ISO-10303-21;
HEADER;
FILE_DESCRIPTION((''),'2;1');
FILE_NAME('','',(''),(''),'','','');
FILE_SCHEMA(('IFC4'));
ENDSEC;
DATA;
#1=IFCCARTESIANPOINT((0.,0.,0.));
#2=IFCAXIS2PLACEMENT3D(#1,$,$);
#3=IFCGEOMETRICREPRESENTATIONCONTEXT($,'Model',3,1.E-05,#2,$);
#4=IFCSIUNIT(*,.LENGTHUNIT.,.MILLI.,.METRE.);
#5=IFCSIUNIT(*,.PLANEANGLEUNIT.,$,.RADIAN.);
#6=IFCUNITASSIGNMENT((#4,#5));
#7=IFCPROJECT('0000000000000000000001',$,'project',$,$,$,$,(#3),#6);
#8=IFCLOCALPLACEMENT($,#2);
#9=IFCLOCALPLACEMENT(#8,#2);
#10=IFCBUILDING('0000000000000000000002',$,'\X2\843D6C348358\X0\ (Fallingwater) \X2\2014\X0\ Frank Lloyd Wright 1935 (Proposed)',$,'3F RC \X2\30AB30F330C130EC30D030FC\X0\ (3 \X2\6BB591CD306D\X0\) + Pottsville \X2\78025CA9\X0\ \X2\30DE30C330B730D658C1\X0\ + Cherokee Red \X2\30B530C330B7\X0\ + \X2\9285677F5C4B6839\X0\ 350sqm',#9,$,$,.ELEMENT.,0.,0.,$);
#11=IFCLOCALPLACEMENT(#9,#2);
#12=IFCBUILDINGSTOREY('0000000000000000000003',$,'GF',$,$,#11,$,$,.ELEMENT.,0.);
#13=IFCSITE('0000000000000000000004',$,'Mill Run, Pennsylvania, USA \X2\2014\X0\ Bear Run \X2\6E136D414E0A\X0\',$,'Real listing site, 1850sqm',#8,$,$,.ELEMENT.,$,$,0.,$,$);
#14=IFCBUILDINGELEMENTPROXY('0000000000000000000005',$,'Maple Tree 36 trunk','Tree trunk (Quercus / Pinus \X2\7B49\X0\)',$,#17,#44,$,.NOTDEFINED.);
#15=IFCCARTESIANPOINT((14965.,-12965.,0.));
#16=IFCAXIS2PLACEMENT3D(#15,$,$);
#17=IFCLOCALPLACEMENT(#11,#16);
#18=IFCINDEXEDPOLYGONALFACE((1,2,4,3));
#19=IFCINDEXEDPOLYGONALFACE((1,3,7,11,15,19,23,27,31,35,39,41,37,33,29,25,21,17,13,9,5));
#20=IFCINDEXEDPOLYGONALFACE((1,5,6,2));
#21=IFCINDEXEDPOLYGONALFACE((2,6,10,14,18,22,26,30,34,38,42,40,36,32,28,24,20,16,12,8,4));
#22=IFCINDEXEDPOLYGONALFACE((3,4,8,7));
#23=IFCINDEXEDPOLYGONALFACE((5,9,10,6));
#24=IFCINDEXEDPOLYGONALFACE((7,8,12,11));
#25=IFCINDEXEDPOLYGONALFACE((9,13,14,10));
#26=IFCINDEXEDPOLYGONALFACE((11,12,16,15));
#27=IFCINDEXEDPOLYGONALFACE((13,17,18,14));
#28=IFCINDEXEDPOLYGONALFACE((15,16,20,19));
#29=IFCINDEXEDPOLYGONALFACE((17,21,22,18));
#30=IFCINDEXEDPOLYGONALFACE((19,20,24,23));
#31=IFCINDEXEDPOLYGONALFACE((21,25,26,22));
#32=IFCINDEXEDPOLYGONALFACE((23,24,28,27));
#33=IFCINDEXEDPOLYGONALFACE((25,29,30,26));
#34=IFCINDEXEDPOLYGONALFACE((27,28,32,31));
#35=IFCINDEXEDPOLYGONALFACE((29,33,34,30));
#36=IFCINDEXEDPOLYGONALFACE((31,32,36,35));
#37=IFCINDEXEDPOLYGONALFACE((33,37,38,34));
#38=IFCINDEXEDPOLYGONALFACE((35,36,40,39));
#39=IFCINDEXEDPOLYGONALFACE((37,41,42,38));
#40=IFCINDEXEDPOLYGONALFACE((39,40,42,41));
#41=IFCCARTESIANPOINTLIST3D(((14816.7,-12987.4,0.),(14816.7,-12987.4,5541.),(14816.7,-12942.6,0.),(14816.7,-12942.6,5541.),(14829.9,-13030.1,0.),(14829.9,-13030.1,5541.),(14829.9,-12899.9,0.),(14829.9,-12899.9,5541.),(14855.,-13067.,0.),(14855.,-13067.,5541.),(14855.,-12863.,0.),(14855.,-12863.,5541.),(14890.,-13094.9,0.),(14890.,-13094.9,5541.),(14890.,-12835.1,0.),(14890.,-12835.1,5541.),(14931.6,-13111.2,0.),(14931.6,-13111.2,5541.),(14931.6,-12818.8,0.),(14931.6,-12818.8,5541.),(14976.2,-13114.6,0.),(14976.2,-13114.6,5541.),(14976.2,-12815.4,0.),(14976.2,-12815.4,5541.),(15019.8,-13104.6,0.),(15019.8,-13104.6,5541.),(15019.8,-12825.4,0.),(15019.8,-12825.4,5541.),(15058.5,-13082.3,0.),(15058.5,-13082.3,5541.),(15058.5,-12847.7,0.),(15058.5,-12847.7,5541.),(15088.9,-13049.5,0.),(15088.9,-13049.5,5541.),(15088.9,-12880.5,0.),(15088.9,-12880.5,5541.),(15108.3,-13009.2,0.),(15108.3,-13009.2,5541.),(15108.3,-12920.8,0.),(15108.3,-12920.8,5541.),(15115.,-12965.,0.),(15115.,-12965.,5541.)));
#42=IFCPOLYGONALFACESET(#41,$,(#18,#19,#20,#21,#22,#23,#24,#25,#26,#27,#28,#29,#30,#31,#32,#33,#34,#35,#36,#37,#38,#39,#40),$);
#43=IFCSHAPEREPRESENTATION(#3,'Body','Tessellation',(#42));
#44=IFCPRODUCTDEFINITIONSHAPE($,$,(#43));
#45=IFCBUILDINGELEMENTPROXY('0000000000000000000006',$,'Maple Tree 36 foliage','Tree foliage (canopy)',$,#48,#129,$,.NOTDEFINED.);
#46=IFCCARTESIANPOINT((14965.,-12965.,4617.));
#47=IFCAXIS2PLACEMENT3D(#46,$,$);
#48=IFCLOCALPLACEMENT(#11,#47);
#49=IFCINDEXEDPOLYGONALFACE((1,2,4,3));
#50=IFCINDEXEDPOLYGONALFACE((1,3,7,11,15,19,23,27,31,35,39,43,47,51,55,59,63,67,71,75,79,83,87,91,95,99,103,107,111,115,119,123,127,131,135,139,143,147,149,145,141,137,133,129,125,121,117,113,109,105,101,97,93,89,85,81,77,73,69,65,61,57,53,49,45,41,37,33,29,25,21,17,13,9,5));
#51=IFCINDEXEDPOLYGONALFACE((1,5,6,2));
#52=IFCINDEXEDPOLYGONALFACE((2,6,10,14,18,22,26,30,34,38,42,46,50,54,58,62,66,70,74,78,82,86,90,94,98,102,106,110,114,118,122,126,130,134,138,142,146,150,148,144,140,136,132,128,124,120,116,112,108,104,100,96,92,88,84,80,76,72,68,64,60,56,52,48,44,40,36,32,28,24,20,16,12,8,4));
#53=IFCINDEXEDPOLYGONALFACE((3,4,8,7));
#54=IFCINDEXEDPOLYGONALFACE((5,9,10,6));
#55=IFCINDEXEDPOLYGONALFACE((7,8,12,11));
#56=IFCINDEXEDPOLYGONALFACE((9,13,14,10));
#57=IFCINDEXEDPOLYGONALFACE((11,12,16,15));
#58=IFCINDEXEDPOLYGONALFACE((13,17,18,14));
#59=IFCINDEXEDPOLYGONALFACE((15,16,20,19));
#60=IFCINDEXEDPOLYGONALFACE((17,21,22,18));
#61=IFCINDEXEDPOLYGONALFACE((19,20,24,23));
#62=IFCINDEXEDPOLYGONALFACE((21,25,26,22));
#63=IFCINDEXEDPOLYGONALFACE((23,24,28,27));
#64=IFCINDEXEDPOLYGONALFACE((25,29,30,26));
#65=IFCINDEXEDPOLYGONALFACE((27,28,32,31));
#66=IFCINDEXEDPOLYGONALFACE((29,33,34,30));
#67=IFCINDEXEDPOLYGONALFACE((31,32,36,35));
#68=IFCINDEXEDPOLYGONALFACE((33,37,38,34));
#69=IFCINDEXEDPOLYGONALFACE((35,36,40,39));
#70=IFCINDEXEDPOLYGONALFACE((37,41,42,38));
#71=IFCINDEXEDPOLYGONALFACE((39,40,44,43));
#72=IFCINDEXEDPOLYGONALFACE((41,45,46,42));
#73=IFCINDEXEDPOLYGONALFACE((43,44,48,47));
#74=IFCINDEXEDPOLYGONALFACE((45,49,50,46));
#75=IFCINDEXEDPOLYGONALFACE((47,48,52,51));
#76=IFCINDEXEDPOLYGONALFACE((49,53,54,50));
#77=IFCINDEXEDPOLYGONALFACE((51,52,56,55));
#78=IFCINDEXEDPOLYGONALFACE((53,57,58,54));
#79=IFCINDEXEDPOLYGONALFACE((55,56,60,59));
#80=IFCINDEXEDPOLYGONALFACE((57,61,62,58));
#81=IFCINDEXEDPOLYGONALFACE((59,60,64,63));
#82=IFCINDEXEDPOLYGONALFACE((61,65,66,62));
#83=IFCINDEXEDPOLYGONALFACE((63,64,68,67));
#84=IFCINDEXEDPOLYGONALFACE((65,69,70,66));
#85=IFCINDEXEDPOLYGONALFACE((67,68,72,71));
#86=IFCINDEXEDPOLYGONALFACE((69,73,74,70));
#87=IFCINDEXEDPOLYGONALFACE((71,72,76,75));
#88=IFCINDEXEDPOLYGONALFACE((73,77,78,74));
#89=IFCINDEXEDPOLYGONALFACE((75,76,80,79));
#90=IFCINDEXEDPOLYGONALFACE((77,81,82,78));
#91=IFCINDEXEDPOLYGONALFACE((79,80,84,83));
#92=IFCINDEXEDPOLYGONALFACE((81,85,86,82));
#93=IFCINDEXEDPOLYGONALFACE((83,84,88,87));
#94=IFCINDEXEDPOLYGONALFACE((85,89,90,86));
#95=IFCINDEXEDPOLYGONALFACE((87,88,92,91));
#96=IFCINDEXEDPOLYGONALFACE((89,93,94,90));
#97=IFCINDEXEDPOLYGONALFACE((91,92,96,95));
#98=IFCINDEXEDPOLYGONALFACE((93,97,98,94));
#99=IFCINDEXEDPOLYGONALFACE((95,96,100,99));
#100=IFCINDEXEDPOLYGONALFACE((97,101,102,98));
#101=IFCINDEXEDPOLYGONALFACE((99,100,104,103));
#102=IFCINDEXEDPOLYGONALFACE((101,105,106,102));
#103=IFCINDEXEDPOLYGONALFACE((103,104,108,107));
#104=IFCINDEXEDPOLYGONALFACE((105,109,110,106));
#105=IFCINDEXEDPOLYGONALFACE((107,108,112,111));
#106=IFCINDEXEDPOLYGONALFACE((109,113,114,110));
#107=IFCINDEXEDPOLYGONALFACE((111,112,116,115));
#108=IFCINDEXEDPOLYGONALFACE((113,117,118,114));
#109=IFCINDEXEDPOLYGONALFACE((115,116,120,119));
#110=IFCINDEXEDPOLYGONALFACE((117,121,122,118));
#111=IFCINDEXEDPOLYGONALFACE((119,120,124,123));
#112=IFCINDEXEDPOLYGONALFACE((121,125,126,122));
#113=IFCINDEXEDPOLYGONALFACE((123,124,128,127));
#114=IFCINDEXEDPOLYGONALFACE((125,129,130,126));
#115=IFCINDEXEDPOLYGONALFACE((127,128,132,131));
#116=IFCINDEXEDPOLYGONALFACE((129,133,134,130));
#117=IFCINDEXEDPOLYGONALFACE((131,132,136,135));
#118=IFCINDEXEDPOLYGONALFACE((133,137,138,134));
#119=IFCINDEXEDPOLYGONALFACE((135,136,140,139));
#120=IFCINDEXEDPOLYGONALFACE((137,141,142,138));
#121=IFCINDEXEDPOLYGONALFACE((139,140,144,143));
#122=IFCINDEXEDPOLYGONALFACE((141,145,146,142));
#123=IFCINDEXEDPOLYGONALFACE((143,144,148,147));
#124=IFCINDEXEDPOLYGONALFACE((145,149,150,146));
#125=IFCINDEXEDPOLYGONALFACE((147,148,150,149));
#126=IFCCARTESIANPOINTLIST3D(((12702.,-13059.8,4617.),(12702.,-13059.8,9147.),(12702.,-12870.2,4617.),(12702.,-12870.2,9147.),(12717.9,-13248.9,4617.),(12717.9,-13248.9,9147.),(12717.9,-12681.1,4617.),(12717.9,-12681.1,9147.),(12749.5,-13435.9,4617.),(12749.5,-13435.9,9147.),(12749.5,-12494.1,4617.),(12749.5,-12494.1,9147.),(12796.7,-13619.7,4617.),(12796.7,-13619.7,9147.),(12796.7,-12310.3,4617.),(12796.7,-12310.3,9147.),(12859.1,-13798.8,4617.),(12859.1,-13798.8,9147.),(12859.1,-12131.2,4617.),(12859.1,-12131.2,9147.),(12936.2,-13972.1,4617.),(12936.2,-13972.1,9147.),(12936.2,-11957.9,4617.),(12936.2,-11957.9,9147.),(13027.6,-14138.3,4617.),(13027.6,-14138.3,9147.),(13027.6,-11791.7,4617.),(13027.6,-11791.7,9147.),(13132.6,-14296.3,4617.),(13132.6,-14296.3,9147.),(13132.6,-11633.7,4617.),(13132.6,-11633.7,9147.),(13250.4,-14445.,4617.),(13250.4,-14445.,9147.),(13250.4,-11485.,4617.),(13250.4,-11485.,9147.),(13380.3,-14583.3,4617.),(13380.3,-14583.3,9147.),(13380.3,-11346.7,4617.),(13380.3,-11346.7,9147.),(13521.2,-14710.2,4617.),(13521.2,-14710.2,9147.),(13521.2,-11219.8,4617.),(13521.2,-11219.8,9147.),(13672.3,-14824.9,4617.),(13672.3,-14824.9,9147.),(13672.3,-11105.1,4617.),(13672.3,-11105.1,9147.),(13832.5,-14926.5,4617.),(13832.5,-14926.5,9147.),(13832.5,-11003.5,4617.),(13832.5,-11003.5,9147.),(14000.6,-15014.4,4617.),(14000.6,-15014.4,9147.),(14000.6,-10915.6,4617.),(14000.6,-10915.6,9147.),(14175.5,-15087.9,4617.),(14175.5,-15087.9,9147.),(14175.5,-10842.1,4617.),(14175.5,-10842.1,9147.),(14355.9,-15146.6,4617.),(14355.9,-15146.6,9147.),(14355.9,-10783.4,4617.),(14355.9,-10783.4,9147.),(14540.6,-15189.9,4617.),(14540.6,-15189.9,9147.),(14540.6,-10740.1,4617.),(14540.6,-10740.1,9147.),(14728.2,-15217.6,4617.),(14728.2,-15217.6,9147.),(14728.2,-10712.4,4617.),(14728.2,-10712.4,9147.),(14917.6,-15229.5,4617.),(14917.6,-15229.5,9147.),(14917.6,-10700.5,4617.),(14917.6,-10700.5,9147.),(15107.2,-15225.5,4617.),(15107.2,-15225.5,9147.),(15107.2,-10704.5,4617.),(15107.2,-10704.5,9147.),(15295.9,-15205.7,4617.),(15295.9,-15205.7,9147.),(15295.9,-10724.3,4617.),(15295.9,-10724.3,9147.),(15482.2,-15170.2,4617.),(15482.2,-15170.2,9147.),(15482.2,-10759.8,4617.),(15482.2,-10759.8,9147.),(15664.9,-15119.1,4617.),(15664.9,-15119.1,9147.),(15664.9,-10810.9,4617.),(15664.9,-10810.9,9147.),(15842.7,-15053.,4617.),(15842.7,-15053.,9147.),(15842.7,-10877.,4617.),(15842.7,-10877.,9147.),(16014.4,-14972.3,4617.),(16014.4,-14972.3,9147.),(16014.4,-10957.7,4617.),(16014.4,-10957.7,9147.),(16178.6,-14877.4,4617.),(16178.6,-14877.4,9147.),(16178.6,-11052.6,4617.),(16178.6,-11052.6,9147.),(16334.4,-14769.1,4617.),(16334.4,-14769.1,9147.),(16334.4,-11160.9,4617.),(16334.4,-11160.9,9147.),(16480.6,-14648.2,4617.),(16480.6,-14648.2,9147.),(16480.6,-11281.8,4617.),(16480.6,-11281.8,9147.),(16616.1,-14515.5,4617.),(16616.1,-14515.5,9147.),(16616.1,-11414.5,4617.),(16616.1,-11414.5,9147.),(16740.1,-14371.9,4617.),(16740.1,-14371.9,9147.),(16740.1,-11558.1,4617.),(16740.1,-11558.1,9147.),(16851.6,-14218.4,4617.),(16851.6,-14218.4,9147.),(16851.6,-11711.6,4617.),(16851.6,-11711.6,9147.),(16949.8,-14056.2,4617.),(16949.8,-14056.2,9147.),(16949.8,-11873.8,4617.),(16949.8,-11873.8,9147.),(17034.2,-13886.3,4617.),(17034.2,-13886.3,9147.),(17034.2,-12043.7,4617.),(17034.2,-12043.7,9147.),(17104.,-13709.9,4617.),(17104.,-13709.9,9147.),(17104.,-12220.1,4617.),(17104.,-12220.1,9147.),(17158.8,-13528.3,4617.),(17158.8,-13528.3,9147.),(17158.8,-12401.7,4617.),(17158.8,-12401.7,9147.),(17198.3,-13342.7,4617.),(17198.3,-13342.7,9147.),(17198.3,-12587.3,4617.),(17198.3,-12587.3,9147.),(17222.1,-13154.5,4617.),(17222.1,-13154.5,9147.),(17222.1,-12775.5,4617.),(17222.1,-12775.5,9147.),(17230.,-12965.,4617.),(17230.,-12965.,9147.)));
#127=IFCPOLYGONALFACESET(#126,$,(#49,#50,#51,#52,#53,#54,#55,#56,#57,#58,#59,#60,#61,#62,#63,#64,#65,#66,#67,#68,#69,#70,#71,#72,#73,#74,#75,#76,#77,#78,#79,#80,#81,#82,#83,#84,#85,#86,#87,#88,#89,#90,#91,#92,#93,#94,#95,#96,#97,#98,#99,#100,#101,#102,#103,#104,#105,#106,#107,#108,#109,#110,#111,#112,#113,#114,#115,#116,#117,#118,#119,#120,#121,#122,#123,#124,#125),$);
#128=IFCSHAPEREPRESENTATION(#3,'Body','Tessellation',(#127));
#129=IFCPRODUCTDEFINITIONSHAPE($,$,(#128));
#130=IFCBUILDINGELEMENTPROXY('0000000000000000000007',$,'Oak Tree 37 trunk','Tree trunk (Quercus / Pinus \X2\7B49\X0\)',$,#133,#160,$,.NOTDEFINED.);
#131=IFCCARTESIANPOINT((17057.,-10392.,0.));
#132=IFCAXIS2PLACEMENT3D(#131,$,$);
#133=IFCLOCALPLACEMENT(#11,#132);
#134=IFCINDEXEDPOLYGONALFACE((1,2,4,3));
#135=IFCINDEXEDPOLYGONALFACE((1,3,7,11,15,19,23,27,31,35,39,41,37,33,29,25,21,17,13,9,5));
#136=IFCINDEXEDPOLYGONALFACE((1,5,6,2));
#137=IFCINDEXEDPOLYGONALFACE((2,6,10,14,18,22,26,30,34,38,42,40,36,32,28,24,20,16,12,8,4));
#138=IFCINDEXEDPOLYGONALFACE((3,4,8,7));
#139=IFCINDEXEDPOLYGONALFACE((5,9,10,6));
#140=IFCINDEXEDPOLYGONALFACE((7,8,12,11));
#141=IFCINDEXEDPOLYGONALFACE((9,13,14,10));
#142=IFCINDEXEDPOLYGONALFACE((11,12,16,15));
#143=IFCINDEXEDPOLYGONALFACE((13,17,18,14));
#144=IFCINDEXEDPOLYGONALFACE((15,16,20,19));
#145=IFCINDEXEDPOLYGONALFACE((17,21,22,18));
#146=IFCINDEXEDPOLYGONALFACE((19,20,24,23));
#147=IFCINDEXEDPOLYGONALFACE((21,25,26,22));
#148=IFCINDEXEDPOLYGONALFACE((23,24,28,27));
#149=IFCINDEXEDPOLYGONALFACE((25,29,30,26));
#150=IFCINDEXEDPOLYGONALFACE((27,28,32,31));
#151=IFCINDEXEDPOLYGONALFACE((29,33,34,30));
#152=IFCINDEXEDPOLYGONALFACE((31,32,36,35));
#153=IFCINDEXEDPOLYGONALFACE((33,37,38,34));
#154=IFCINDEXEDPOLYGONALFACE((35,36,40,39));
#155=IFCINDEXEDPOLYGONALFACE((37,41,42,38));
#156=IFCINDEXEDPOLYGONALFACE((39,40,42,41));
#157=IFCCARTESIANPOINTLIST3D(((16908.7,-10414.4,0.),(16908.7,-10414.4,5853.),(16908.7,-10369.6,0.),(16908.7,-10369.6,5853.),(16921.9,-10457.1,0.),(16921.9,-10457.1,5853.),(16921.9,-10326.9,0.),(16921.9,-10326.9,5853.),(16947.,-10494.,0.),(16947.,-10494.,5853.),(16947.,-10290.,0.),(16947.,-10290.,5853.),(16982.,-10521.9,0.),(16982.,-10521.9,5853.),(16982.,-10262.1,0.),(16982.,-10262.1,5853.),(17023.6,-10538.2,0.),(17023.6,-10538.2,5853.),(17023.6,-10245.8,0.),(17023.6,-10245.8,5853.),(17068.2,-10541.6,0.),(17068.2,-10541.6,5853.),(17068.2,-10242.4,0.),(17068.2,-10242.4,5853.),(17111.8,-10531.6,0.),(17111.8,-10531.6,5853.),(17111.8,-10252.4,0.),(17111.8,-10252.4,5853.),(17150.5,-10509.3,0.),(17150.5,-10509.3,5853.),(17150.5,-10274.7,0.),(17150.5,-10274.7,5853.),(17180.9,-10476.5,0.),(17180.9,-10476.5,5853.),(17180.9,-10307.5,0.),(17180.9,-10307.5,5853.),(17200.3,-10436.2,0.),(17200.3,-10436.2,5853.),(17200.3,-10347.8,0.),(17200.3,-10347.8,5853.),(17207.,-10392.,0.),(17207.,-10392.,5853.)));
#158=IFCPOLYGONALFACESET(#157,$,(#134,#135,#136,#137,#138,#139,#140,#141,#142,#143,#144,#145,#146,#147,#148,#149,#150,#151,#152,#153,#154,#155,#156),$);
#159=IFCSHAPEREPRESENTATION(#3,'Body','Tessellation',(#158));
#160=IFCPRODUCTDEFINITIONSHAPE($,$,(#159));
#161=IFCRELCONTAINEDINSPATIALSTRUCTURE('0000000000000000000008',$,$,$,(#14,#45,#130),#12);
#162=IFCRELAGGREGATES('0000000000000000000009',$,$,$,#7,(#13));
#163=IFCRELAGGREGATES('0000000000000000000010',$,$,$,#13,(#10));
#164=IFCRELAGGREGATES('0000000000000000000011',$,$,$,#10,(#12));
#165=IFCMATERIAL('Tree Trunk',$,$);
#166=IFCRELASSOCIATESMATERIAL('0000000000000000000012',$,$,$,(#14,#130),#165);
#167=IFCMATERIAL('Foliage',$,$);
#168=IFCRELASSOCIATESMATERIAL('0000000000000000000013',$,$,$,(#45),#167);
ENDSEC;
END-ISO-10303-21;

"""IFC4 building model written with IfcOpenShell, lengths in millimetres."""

from ifc_helpers import new_model, si_unit, frame, origin, origin_2d, place, context, project, spatial, circle, extrude, material, element, save


model = new_model("IFC4")

# Units and contexts
model_context = context("Model", 3, precision=1e-05, world=origin())
ifc_project = project(units=[si_unit("LENGTHUNIT", "METRE", prefix="MILLI"), si_unit("PLANEANGLEUNIT", "RADIAN")], contexts=[model_context])

# Site, building, storey
site_placement = place(None, origin())
site = spatial("IfcSite", under=ifc_project, at=site_placement, Name="Mill Run, Pennsylvania, USA — Bear Run 渓流上", ObjectType="Real listing site, 1850sqm", CompositionType="ELEMENT", RefElevation=0.0)
building_placement = place(site_placement, origin())
building = spatial("IfcBuilding", under=site, at=building_placement, Name="落水荘 (Fallingwater) — Frank Lloyd Wright 1935 (Proposed)", ObjectType="3F RC カンチレバー (3 段重ね) + Pottsville 砂岩 マッシブ壁 + Cherokee Red サッシ + 銅板屋根 350sqm", CompositionType="ELEMENT", ElevationOfRefHeight=0.0, ElevationOfTerrain=0.0)
storey_placement = place(building_placement, origin())
storey = spatial("IfcBuildingStorey", under=building, at=storey_placement, Name="GF", CompositionType="ELEMENT", Elevation=0.0)

# Building element proxies
ifc_material_1 = material(Name="Tree Trunk")
ifc_material_2 = material(Name="Foliage")
proxy_1_placement = place(storey_placement, frame((14965.0, -12965.0, 0.0)))
element("IfcBuildingElementProxy", 1, at=proxy_1_placement, inside=storey, material=ifc_material_1, Name="Maple Tree 36 trunk", Description="Tree trunk (Quercus / Pinus 等)", PredefinedType="NOTDEFINED", context=model_context, shape_type="SweptSolid", body=[
    extrude(circle(Radius=150.0, at=origin_2d()), frame((14965.0, -12965.0, 0.0)), (0.0, 0.0, 1.0), 5541.0),
])
proxy_2_placement = place(storey_placement, frame((14965.0, -12965.0, 4617.0)))
element("IfcBuildingElementProxy", 2, at=proxy_2_placement, inside=storey, material=ifc_material_2, Name="Maple Tree 36 foliage", Description="Tree foliage (canopy)", PredefinedType="NOTDEFINED", context=model_context, shape_type="SweptSolid", body=[
    extrude(circle(Radius=2265.0, at=origin_2d()), frame((14965.0, -12965.0, 4617.0)), (0.0, 0.0, 1.0), 4530.0),
])
proxy_3_placement = place(storey_placement, frame((17057.0, -10392.0, 0.0)))
element("IfcBuildingElementProxy", 3, at=proxy_3_placement, inside=storey, material=ifc_material_1, Name="Oak Tree 37 trunk", Description="Tree trunk (Quercus / Pinus 等)", PredefinedType="NOTDEFINED", context=model_context, shape_type="SweptSolid", body=[
    extrude(circle(Radius=150.0, at=origin_2d()), frame((17057.0, -10392.0, 0.0)), (0.0, 0.0, 1.0), 5853.0),
])

save(model, "model.ifc")
